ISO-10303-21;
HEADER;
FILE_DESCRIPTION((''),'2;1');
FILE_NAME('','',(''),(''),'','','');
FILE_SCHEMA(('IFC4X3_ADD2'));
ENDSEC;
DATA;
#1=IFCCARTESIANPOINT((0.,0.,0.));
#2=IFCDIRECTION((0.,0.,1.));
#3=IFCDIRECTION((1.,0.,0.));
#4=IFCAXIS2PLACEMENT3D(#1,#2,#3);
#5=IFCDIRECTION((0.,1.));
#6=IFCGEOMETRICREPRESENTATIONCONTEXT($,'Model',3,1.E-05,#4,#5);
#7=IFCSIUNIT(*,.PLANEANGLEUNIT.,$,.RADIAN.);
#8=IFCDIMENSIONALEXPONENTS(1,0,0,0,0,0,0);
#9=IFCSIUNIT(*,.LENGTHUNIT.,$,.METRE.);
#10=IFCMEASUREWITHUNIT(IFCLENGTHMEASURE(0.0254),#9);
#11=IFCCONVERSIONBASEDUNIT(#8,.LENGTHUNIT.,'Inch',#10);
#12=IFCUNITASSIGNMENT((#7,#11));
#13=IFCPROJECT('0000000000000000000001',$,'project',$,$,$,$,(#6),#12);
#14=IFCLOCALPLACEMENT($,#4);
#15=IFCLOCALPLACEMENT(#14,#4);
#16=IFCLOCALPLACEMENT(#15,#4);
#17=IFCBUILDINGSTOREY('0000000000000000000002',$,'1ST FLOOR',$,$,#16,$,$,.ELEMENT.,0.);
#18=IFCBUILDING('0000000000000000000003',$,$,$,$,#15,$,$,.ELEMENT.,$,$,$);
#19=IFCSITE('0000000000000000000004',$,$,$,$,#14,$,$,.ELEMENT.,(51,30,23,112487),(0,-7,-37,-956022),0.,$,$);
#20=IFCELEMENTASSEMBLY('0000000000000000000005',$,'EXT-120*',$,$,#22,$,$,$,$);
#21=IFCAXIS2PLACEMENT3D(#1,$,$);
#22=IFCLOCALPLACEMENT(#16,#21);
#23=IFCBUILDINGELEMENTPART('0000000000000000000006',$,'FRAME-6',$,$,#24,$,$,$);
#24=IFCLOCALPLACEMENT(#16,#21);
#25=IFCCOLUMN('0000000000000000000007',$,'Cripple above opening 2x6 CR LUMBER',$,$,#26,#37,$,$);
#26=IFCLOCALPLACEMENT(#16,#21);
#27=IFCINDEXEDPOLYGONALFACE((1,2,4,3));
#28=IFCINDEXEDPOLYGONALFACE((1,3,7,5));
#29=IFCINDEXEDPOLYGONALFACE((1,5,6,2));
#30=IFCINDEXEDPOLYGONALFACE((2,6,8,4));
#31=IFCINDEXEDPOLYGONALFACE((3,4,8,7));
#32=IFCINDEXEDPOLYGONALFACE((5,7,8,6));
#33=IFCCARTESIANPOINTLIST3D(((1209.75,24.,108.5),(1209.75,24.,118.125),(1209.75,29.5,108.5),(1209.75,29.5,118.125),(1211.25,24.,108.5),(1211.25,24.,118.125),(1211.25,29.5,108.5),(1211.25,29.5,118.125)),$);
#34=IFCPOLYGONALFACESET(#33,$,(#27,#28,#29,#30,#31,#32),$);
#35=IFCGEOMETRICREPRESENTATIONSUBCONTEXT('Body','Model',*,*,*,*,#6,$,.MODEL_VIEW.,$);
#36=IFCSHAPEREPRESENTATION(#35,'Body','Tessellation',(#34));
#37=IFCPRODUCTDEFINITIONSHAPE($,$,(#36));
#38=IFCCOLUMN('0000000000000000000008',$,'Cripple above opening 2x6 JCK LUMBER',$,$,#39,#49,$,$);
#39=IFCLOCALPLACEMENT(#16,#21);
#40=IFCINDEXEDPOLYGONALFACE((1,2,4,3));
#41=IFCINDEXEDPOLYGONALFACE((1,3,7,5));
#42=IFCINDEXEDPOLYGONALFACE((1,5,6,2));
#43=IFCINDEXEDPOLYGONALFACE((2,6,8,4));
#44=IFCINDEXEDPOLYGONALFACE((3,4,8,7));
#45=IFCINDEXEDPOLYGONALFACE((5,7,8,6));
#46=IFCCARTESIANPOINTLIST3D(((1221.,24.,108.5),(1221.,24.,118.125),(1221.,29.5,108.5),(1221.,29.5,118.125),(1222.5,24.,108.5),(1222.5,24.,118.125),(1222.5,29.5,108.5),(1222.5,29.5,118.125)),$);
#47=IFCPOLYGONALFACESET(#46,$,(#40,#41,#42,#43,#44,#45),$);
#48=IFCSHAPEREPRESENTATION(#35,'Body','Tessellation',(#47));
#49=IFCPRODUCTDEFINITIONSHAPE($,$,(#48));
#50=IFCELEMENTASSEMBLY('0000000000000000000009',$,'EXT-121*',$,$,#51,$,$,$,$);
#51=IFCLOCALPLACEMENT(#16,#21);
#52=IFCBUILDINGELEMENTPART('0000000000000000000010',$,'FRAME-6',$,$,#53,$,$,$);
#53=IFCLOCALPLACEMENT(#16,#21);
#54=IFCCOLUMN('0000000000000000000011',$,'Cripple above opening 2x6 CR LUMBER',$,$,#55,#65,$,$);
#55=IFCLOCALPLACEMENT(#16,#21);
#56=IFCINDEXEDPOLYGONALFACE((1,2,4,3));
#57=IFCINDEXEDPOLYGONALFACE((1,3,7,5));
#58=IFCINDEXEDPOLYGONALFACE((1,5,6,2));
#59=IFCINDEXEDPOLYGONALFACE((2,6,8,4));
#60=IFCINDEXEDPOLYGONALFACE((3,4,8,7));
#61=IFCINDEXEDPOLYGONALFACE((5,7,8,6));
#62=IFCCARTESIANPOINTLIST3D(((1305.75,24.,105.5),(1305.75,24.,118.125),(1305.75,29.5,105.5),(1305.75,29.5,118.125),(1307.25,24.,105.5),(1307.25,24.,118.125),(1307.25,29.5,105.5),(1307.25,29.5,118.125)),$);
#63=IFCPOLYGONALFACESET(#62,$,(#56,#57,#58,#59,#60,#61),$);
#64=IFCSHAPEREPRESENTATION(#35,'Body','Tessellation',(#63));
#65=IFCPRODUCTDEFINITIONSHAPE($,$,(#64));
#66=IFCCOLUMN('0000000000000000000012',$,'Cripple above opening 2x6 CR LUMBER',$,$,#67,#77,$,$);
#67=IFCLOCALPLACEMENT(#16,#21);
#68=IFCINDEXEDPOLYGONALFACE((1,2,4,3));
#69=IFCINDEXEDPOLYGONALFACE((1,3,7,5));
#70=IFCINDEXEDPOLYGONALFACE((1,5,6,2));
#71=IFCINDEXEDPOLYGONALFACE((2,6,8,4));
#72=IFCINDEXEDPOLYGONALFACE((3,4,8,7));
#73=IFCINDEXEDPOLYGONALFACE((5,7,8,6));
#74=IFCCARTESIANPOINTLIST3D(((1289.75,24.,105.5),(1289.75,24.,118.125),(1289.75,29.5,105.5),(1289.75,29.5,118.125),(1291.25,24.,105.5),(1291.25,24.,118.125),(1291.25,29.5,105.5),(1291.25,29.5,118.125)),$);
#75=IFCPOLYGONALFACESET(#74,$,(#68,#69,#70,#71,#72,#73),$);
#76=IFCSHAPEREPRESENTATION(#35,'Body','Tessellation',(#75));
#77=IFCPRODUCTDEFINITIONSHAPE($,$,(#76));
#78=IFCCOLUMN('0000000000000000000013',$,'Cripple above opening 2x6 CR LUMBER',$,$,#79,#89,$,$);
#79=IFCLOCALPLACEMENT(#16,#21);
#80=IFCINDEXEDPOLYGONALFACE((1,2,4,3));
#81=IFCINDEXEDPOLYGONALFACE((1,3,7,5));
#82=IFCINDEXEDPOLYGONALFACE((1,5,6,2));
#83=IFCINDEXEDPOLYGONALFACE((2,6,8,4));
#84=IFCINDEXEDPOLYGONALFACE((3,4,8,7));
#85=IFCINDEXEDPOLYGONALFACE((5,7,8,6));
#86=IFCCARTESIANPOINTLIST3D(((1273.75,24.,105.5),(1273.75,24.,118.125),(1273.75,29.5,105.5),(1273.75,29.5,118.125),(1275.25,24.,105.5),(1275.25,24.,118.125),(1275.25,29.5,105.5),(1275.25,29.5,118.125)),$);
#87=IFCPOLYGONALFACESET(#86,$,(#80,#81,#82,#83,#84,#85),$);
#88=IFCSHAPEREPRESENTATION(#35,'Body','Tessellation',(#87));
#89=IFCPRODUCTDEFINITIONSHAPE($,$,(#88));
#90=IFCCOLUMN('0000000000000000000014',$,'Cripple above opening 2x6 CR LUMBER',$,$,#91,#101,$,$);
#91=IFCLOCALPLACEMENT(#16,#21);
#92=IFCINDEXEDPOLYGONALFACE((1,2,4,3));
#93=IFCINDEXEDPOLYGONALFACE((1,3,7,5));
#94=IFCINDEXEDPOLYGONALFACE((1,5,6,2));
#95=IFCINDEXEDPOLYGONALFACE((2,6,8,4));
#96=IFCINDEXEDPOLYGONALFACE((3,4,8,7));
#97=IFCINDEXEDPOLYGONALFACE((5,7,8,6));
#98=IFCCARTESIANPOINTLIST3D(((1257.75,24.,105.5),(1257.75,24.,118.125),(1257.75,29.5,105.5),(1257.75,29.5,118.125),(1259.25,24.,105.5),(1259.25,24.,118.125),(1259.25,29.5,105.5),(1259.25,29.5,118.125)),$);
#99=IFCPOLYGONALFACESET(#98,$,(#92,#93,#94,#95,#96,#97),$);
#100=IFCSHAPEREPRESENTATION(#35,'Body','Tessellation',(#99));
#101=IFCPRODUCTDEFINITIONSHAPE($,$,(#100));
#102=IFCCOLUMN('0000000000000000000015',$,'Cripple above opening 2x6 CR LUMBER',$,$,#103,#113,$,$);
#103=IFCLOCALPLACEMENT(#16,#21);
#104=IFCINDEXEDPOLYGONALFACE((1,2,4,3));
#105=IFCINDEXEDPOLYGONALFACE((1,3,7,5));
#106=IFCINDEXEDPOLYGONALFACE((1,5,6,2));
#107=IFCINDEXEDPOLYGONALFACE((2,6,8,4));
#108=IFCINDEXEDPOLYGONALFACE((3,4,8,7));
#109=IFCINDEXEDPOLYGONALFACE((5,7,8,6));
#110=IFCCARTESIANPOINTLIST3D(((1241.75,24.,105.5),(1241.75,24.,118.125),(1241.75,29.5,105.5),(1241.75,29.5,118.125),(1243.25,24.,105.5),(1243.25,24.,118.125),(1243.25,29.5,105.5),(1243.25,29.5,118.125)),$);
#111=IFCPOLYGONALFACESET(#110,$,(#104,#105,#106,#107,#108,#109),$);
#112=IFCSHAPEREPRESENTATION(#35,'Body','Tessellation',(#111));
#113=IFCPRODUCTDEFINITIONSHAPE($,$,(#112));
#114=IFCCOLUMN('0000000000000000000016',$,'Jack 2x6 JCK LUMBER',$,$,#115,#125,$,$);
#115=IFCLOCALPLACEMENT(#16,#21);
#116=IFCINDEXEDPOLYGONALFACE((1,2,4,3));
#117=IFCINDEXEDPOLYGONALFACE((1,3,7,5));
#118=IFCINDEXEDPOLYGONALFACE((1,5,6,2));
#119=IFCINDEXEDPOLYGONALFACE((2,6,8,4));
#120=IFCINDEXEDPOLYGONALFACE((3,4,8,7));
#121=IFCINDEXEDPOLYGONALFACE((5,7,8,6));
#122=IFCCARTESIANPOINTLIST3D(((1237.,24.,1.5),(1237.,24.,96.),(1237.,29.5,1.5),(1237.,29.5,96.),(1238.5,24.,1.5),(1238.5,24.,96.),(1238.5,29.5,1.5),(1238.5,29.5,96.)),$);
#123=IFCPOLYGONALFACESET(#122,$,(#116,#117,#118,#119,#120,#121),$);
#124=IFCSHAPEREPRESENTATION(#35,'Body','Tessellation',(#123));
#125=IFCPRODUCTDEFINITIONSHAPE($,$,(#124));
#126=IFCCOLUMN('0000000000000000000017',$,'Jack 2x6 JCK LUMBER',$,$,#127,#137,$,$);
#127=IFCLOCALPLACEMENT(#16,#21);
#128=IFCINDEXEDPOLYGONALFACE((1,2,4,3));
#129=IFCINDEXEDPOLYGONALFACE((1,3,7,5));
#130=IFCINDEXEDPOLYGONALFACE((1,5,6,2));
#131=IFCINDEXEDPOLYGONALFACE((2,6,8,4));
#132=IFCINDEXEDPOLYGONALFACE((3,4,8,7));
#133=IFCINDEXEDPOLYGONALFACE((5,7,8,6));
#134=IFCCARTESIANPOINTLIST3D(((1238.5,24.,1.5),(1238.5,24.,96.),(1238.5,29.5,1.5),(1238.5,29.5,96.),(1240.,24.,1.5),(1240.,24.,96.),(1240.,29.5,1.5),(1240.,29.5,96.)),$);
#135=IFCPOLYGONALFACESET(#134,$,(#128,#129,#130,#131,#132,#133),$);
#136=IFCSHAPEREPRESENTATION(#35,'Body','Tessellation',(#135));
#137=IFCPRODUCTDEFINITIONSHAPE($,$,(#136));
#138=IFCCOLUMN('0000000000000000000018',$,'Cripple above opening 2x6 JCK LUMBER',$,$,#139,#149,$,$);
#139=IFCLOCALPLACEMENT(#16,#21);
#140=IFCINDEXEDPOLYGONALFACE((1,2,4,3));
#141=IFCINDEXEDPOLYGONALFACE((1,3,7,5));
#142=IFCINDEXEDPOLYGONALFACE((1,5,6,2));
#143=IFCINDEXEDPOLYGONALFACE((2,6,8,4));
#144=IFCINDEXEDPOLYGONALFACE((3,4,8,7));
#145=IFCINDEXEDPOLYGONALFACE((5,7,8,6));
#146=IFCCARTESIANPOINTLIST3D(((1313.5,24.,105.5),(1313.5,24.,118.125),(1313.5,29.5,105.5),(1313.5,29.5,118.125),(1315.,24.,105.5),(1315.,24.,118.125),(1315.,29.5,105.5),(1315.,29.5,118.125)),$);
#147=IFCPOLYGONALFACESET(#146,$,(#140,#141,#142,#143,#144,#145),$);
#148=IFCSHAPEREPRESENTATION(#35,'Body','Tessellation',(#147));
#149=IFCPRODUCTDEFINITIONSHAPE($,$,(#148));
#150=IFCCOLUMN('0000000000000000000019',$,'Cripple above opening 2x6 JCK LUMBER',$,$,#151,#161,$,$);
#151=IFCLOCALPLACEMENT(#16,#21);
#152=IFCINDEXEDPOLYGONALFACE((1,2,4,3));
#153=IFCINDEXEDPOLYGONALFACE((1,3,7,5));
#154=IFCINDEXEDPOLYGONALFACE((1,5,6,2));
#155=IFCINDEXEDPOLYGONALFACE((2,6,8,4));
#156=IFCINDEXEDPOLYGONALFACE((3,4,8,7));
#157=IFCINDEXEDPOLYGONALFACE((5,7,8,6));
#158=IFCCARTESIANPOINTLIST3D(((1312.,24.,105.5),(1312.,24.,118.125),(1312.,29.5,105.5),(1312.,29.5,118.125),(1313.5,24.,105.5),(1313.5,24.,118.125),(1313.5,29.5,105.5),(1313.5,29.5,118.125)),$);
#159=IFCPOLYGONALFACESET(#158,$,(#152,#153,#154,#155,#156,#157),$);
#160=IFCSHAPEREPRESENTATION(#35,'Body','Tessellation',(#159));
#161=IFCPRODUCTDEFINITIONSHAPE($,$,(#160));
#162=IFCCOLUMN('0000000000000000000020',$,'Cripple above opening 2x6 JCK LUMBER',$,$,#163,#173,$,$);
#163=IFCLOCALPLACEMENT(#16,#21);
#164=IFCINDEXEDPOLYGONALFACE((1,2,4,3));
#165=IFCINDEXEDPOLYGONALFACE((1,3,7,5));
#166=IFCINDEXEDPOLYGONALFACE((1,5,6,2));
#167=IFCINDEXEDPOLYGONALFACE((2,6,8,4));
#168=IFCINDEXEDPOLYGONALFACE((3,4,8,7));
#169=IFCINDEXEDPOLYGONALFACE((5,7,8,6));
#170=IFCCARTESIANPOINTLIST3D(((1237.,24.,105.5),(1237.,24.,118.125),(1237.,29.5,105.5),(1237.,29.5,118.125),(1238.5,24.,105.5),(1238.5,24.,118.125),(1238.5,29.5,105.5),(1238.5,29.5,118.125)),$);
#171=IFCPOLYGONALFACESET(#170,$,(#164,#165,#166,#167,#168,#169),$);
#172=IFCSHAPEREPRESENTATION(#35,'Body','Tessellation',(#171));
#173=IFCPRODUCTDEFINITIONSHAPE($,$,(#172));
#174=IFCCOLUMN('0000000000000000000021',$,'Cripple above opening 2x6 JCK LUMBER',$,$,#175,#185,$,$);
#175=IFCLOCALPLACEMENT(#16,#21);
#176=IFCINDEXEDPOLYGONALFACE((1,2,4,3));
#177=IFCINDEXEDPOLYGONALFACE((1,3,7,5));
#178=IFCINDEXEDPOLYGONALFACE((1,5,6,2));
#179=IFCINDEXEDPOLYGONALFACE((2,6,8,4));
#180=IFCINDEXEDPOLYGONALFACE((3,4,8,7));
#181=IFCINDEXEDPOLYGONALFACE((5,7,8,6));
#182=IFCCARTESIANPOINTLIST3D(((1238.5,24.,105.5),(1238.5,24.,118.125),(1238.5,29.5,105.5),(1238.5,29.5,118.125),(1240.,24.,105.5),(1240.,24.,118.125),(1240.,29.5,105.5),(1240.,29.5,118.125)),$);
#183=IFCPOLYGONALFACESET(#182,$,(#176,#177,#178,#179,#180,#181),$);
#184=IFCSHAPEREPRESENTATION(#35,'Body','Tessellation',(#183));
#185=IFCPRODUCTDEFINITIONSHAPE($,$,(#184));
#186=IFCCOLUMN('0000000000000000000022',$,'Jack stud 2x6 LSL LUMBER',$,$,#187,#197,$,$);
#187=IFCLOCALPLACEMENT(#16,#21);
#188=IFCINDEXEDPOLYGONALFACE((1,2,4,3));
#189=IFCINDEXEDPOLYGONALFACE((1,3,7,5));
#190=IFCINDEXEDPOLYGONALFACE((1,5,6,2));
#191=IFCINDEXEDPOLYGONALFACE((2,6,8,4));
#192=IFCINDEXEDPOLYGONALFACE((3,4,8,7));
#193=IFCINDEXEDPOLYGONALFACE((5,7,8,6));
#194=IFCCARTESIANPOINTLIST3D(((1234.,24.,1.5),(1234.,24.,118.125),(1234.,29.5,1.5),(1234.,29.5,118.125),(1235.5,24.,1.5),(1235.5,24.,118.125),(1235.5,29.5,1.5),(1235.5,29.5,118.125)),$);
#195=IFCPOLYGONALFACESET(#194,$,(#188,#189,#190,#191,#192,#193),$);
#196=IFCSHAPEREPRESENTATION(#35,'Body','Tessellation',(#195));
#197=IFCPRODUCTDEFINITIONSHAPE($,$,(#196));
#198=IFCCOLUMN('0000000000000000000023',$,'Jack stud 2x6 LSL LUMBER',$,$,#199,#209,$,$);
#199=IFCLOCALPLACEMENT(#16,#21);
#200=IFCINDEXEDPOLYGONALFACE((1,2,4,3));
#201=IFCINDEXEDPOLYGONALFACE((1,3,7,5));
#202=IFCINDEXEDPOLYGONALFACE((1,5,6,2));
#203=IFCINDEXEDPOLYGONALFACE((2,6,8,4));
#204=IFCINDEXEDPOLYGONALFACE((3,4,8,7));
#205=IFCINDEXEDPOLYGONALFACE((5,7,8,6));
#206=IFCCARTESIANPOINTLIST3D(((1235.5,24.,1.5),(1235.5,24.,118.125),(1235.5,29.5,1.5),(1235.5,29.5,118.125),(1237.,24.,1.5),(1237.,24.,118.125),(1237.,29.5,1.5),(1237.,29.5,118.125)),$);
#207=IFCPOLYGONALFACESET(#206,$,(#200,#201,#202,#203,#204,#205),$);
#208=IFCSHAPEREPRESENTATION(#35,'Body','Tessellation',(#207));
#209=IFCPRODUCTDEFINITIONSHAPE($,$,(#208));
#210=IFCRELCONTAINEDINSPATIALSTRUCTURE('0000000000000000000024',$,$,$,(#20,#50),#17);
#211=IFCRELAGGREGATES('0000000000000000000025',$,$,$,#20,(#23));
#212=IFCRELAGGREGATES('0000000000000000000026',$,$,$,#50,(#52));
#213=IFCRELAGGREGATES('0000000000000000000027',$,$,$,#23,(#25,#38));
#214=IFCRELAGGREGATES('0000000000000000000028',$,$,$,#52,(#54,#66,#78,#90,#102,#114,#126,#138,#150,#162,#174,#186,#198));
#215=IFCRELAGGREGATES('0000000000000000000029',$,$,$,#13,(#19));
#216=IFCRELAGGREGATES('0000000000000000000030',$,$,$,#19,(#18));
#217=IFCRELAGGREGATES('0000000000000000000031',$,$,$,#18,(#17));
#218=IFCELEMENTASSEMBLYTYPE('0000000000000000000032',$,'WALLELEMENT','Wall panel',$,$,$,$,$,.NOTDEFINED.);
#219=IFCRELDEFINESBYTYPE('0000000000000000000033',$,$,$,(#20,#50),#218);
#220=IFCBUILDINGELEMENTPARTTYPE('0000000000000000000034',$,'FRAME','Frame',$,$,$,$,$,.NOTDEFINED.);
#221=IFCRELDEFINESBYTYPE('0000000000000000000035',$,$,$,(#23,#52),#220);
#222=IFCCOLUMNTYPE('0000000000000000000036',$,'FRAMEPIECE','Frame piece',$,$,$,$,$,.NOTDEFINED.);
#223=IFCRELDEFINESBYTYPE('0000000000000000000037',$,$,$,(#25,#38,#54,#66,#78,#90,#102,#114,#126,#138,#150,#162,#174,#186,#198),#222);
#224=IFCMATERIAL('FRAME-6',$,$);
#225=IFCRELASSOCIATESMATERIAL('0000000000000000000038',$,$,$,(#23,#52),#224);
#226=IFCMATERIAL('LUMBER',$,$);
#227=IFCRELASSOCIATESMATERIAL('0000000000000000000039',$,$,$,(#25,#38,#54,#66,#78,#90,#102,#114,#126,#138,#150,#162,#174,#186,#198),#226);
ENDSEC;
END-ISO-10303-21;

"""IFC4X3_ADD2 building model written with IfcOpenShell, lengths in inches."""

from ifc_helpers import new_model, entity, si_unit, converted_unit, direction, frame, origin_with_axes, origin_2d_with_axis, place, context, subcontext, project, spatial, rectangle, extrude, material, type_object, element, aggregate, save


model = new_model("IFC4X3_ADD2")

# Units and contexts
model_context = context("Model", 3, precision=1e-05, world=origin_with_axes(), true_north=direction((0.0, 1.0)))
body_context = subcontext(model_context, "Body", "Model", "MODEL_VIEW")
ifc_project = project(units=[si_unit("PLANEANGLEUNIT", "RADIAN"), converted_unit("LENGTHUNIT", "Inch", entity("IfcLengthMeasure", 0.0254), si_unit("LENGTHUNIT", "METRE"), dimensions=[1, 0, 0, 0, 0, 0, 0])], contexts=[model_context])

# Site, building, storey
site_placement = place(None, origin_with_axes())
site = spatial("IfcSite", under=ifc_project, at=site_placement, CompositionType="ELEMENT", RefLatitude=(51, 30, 23, 112487), RefLongitude=(0, -7, -37, -956022), RefElevation=0.0)
building_placement = place(site_placement, origin_with_axes())
building = spatial("IfcBuilding", under=site, at=building_placement, CompositionType="ELEMENT")
storey_placement = place(building_placement, origin_with_axes())
storey = spatial("IfcBuildingStorey", under=building, at=storey_placement, Name="1ST FLOOR", CompositionType="ELEMENT", Elevation=0.0)

# Element assemblies, building element parts, columns
element_assembly_type = type_object("IfcElementAssemblyType", Name="WALLELEMENT", Description="Wall panel", PredefinedType="NOTDEFINED")
assembly_1_placement = place(storey_placement, origin_with_axes())
assembly_1 = element("IfcElementAssembly", 1, at=assembly_1_placement, inside=storey, type_object=element_assembly_type, Name="EXT-120*")
ifc_material_1 = material(Name="FRAME-6")
building_element_part_type = type_object("IfcBuildingElementPartType", Name="FRAME", Description="Frame", PredefinedType="NOTDEFINED")
building_element_part_1_placement = place(storey_placement, origin_with_axes())
building_element_part_1 = element("IfcBuildingElementPart", 2, at=building_element_part_1_placement, type_object=building_element_part_type, material=ifc_material_1, Name="FRAME-6")
aggregate(assembly_1, [building_element_part_1])
ifc_material_2 = material(Name="LUMBER")
column_type = type_object("IfcColumnType", Name="FRAMEPIECE", Description="Frame piece", PredefinedType="NOTDEFINED")
column_1_placement = place(storey_placement, frame((1210.5, 26.75, 118.125), z_axis=(0.0, 0.0, -1.0), x_axis=(1.0, 0.0, 0.0)))
column_1 = element("IfcColumn", 3, at=column_1_placement, type_object=column_type, material=ifc_material_2, Name="Cripple above opening 2x6 CR LUMBER", context=body_context, shape_type="SweptSolid", body=[
    extrude(rectangle(XDim=1.5, YDim=5.5, at=origin_2d_with_axis()), origin_with_axes(), (0.0, 0.0, 1.0), 9.625),
])
column_2_placement = place(storey_placement, frame((1221.75, 26.75, 108.5), z_axis=(0.0, 0.0, 1.0), x_axis=(-1.0, 0.0, 0.0)))
column_2 = element("IfcColumn", 4, at=column_2_placement, type_object=column_type, material=ifc_material_2, Name="Cripple above opening 2x6 JCK LUMBER", context=body_context, shape_type="SweptSolid", body=[
    extrude(rectangle(XDim=1.5, YDim=5.5, at=origin_2d_with_axis()), origin_with_axes(), (0.0, 0.0, 1.0), 9.625),
])
assembly_2_placement = place(storey_placement, origin_with_axes())
assembly_2 = element("IfcElementAssembly", 5, at=assembly_2_placement, inside=storey, type_object=element_assembly_type, Name="EXT-121*")
building_element_part_2_placement = place(storey_placement, origin_with_axes())
building_element_part_2 = element("IfcBuildingElementPart", 6, at=building_element_part_2_placement, type_object=building_element_part_type, material=ifc_material_1, Name="FRAME-6")
aggregate(assembly_2, [building_element_part_2])
column_3_placement = place(storey_placement, frame((1306.5, 26.75, 118.125), z_axis=(0.0, 0.0, -1.0), x_axis=(1.0, 0.0, 0.0)))
column_3 = element("IfcColumn", 7, at=column_3_placement, type_object=column_type, material=ifc_material_2, Name="Cripple above opening 2x6 CR LUMBER", context=body_context, shape_type="SweptSolid", body=[
    extrude(rectangle(XDim=1.5, YDim=5.5, at=origin_2d_with_axis()), origin_with_axes(), (0.0, 0.0, 1.0), 12.625),
])
column_4_placement = place(storey_placement, frame((1290.5, 26.75, 118.125), z_axis=(0.0, 0.0, -1.0), x_axis=(1.0, 0.0, 0.0)))
column_4 = element("IfcColumn", 8, at=column_4_placement, type_object=column_type, material=ifc_material_2, Name="Cripple above opening 2x6 CR LUMBER", context=body_context, shape_type="SweptSolid", body=[
    extrude(rectangle(XDim=1.5, YDim=5.5, at=origin_2d_with_axis()), origin_with_axes(), (0.0, 0.0, 1.0), 12.625),
])
column_5_placement = place(storey_placement, frame((1274.5, 26.75, 118.125), z_axis=(0.0, 0.0, -1.0), x_axis=(1.0, 0.0, 0.0)))
column_5 = element("IfcColumn", 9, at=column_5_placement, type_object=column_type, material=ifc_material_2, Name="Cripple above opening 2x6 CR LUMBER", context=body_context, shape_type="SweptSolid", body=[
    extrude(rectangle(XDim=1.5, YDim=5.5, at=origin_2d_with_axis()), origin_with_axes(), (0.0, 0.0, 1.0), 12.625),
])
column_6_placement = place(storey_placement, frame((1258.5, 26.75, 118.125), z_axis=(0.0, 0.0, -1.0), x_axis=(1.0, 0.0, 0.0)))
column_6 = element("IfcColumn", 10, at=column_6_placement, type_object=column_type, material=ifc_material_2, Name="Cripple above opening 2x6 CR LUMBER", context=body_context, shape_type="SweptSolid", body=[
    extrude(rectangle(XDim=1.5, YDim=5.5, at=origin_2d_with_axis()), origin_with_axes(), (0.0, 0.0, 1.0), 12.625),
])
column_7_placement = place(storey_placement, frame((1242.5, 26.75, 118.125), z_axis=(0.0, 0.0, -1.0), x_axis=(1.0, 0.0, 0.0)))
column_7 = element("IfcColumn", 11, at=column_7_placement, type_object=column_type, material=ifc_material_2, Name="Cripple above opening 2x6 CR LUMBER", context=body_context, shape_type="SweptSolid", body=[
    extrude(rectangle(XDim=1.5, YDim=5.5, at=origin_2d_with_axis()), origin_with_axes(), (0.0, 0.0, 1.0), 12.625),
])
column_8_placement = place(storey_placement, frame((1237.75, 26.75, 96.0), z_axis=(0.0, 0.0, -1.0), x_axis=(1.0, 0.0, 0.0)))
column_8 = element("IfcColumn", 12, at=column_8_placement, type_object=column_type, material=ifc_material_2, Name="Jack 2x6 JCK LUMBER", context=body_context, shape_type="SweptSolid", body=[
    extrude(rectangle(XDim=1.5, YDim=5.5, at=origin_2d_with_axis()), origin_with_axes(), (0.0, 0.0, 1.0), 94.5),
])
column_9_placement = place(storey_placement, frame((1239.25, 26.75, 96.0), z_axis=(0.0, 0.0, -1.0), x_axis=(1.0, 0.0, 0.0)))
column_9 = element("IfcColumn", 13, at=column_9_placement, type_object=column_type, material=ifc_material_2, Name="Jack 2x6 JCK LUMBER", context=body_context, shape_type="SweptSolid", body=[
    extrude(rectangle(XDim=1.5, YDim=5.5, at=origin_2d_with_axis()), origin_with_axes(), (0.0, 0.0, 1.0), 94.5),
])
column_10_placement = place(storey_placement, frame((1314.25, 26.75, 105.5), z_axis=(0.0, 0.0, 1.0), x_axis=(-1.0, 0.0, 0.0)))
column_10 = element("IfcColumn", 14, at=column_10_placement, type_object=column_type, material=ifc_material_2, Name="Cripple above opening 2x6 JCK LUMBER", context=body_context, shape_type="SweptSolid", body=[
    extrude(rectangle(XDim=1.5, YDim=5.5, at=origin_2d_with_axis()), origin_with_axes(), (0.0, 0.0, 1.0), 12.625),
])
column_11_placement = place(storey_placement, frame((1312.75, 26.75, 105.5), z_axis=(0.0, 0.0, 1.0), x_axis=(-1.0, 0.0, 0.0)))
column_11 = element("IfcColumn", 15, at=column_11_placement, type_object=column_type, material=ifc_material_2, Name="Cripple above opening 2x6 JCK LUMBER", context=body_context, shape_type="SweptSolid", body=[
    extrude(rectangle(XDim=1.5, YDim=5.5, at=origin_2d_with_axis()), origin_with_axes(), (0.0, 0.0, 1.0), 12.625),
])
column_12_placement = place(storey_placement, frame((1237.75, 26.75, 118.125), z_axis=(0.0, 0.0, -1.0), x_axis=(1.0, 0.0, 0.0)))
column_12 = element("IfcColumn", 16, at=column_12_placement, type_object=column_type, material=ifc_material_2, Name="Cripple above opening 2x6 JCK LUMBER", context=body_context, shape_type="SweptSolid", body=[
    extrude(rectangle(XDim=1.5, YDim=5.5, at=origin_2d_with_axis()), origin_with_axes(), (0.0, 0.0, 1.0), 12.625),
])
column_13_placement = place(storey_placement, frame((1239.25, 26.75, 118.125), z_axis=(0.0, 0.0, -1.0), x_axis=(1.0, 0.0, 0.0)))
column_13 = element("IfcColumn", 17, at=column_13_placement, type_object=column_type, material=ifc_material_2, Name="Cripple above opening 2x6 JCK LUMBER", context=body_context, shape_type="SweptSolid", body=[
    extrude(rectangle(XDim=1.5, YDim=5.5, at=origin_2d_with_axis()), origin_with_axes(), (0.0, 0.0, 1.0), 12.625),
])
column_14_placement = place(storey_placement, frame((1234.75, 26.75, 118.125), z_axis=(0.0, 0.0, -1.0), x_axis=(1.0, 0.0, 0.0)))
column_14 = element("IfcColumn", 18, at=column_14_placement, type_object=column_type, material=ifc_material_2, Name="Jack stud 2x6 LSL LUMBER", context=body_context, shape_type="SweptSolid", body=[
    extrude(rectangle(XDim=1.5, YDim=5.5, at=origin_2d_with_axis()), origin_with_axes(), (0.0, 0.0, 1.0), 116.625),
])
column_15_placement = place(storey_placement, frame((1236.25, 26.75, 118.125), z_axis=(0.0, 0.0, -1.0), x_axis=(1.0, 0.0, 0.0)))
column_15 = element("IfcColumn", 19, at=column_15_placement, type_object=column_type, material=ifc_material_2, Name="Jack stud 2x6 LSL LUMBER", context=body_context, shape_type="SweptSolid", body=[
    extrude(rectangle(XDim=1.5, YDim=5.5, at=origin_2d_with_axis()), origin_with_axes(), (0.0, 0.0, 1.0), 116.625),
])

aggregate(building_element_part_1, [column_1, column_2])
aggregate(building_element_part_2, [column_3, column_4, column_5, column_6, column_7, column_8, column_9, column_10, column_11, column_12, column_13, column_14, column_15])

save(model, "model.ifc")
